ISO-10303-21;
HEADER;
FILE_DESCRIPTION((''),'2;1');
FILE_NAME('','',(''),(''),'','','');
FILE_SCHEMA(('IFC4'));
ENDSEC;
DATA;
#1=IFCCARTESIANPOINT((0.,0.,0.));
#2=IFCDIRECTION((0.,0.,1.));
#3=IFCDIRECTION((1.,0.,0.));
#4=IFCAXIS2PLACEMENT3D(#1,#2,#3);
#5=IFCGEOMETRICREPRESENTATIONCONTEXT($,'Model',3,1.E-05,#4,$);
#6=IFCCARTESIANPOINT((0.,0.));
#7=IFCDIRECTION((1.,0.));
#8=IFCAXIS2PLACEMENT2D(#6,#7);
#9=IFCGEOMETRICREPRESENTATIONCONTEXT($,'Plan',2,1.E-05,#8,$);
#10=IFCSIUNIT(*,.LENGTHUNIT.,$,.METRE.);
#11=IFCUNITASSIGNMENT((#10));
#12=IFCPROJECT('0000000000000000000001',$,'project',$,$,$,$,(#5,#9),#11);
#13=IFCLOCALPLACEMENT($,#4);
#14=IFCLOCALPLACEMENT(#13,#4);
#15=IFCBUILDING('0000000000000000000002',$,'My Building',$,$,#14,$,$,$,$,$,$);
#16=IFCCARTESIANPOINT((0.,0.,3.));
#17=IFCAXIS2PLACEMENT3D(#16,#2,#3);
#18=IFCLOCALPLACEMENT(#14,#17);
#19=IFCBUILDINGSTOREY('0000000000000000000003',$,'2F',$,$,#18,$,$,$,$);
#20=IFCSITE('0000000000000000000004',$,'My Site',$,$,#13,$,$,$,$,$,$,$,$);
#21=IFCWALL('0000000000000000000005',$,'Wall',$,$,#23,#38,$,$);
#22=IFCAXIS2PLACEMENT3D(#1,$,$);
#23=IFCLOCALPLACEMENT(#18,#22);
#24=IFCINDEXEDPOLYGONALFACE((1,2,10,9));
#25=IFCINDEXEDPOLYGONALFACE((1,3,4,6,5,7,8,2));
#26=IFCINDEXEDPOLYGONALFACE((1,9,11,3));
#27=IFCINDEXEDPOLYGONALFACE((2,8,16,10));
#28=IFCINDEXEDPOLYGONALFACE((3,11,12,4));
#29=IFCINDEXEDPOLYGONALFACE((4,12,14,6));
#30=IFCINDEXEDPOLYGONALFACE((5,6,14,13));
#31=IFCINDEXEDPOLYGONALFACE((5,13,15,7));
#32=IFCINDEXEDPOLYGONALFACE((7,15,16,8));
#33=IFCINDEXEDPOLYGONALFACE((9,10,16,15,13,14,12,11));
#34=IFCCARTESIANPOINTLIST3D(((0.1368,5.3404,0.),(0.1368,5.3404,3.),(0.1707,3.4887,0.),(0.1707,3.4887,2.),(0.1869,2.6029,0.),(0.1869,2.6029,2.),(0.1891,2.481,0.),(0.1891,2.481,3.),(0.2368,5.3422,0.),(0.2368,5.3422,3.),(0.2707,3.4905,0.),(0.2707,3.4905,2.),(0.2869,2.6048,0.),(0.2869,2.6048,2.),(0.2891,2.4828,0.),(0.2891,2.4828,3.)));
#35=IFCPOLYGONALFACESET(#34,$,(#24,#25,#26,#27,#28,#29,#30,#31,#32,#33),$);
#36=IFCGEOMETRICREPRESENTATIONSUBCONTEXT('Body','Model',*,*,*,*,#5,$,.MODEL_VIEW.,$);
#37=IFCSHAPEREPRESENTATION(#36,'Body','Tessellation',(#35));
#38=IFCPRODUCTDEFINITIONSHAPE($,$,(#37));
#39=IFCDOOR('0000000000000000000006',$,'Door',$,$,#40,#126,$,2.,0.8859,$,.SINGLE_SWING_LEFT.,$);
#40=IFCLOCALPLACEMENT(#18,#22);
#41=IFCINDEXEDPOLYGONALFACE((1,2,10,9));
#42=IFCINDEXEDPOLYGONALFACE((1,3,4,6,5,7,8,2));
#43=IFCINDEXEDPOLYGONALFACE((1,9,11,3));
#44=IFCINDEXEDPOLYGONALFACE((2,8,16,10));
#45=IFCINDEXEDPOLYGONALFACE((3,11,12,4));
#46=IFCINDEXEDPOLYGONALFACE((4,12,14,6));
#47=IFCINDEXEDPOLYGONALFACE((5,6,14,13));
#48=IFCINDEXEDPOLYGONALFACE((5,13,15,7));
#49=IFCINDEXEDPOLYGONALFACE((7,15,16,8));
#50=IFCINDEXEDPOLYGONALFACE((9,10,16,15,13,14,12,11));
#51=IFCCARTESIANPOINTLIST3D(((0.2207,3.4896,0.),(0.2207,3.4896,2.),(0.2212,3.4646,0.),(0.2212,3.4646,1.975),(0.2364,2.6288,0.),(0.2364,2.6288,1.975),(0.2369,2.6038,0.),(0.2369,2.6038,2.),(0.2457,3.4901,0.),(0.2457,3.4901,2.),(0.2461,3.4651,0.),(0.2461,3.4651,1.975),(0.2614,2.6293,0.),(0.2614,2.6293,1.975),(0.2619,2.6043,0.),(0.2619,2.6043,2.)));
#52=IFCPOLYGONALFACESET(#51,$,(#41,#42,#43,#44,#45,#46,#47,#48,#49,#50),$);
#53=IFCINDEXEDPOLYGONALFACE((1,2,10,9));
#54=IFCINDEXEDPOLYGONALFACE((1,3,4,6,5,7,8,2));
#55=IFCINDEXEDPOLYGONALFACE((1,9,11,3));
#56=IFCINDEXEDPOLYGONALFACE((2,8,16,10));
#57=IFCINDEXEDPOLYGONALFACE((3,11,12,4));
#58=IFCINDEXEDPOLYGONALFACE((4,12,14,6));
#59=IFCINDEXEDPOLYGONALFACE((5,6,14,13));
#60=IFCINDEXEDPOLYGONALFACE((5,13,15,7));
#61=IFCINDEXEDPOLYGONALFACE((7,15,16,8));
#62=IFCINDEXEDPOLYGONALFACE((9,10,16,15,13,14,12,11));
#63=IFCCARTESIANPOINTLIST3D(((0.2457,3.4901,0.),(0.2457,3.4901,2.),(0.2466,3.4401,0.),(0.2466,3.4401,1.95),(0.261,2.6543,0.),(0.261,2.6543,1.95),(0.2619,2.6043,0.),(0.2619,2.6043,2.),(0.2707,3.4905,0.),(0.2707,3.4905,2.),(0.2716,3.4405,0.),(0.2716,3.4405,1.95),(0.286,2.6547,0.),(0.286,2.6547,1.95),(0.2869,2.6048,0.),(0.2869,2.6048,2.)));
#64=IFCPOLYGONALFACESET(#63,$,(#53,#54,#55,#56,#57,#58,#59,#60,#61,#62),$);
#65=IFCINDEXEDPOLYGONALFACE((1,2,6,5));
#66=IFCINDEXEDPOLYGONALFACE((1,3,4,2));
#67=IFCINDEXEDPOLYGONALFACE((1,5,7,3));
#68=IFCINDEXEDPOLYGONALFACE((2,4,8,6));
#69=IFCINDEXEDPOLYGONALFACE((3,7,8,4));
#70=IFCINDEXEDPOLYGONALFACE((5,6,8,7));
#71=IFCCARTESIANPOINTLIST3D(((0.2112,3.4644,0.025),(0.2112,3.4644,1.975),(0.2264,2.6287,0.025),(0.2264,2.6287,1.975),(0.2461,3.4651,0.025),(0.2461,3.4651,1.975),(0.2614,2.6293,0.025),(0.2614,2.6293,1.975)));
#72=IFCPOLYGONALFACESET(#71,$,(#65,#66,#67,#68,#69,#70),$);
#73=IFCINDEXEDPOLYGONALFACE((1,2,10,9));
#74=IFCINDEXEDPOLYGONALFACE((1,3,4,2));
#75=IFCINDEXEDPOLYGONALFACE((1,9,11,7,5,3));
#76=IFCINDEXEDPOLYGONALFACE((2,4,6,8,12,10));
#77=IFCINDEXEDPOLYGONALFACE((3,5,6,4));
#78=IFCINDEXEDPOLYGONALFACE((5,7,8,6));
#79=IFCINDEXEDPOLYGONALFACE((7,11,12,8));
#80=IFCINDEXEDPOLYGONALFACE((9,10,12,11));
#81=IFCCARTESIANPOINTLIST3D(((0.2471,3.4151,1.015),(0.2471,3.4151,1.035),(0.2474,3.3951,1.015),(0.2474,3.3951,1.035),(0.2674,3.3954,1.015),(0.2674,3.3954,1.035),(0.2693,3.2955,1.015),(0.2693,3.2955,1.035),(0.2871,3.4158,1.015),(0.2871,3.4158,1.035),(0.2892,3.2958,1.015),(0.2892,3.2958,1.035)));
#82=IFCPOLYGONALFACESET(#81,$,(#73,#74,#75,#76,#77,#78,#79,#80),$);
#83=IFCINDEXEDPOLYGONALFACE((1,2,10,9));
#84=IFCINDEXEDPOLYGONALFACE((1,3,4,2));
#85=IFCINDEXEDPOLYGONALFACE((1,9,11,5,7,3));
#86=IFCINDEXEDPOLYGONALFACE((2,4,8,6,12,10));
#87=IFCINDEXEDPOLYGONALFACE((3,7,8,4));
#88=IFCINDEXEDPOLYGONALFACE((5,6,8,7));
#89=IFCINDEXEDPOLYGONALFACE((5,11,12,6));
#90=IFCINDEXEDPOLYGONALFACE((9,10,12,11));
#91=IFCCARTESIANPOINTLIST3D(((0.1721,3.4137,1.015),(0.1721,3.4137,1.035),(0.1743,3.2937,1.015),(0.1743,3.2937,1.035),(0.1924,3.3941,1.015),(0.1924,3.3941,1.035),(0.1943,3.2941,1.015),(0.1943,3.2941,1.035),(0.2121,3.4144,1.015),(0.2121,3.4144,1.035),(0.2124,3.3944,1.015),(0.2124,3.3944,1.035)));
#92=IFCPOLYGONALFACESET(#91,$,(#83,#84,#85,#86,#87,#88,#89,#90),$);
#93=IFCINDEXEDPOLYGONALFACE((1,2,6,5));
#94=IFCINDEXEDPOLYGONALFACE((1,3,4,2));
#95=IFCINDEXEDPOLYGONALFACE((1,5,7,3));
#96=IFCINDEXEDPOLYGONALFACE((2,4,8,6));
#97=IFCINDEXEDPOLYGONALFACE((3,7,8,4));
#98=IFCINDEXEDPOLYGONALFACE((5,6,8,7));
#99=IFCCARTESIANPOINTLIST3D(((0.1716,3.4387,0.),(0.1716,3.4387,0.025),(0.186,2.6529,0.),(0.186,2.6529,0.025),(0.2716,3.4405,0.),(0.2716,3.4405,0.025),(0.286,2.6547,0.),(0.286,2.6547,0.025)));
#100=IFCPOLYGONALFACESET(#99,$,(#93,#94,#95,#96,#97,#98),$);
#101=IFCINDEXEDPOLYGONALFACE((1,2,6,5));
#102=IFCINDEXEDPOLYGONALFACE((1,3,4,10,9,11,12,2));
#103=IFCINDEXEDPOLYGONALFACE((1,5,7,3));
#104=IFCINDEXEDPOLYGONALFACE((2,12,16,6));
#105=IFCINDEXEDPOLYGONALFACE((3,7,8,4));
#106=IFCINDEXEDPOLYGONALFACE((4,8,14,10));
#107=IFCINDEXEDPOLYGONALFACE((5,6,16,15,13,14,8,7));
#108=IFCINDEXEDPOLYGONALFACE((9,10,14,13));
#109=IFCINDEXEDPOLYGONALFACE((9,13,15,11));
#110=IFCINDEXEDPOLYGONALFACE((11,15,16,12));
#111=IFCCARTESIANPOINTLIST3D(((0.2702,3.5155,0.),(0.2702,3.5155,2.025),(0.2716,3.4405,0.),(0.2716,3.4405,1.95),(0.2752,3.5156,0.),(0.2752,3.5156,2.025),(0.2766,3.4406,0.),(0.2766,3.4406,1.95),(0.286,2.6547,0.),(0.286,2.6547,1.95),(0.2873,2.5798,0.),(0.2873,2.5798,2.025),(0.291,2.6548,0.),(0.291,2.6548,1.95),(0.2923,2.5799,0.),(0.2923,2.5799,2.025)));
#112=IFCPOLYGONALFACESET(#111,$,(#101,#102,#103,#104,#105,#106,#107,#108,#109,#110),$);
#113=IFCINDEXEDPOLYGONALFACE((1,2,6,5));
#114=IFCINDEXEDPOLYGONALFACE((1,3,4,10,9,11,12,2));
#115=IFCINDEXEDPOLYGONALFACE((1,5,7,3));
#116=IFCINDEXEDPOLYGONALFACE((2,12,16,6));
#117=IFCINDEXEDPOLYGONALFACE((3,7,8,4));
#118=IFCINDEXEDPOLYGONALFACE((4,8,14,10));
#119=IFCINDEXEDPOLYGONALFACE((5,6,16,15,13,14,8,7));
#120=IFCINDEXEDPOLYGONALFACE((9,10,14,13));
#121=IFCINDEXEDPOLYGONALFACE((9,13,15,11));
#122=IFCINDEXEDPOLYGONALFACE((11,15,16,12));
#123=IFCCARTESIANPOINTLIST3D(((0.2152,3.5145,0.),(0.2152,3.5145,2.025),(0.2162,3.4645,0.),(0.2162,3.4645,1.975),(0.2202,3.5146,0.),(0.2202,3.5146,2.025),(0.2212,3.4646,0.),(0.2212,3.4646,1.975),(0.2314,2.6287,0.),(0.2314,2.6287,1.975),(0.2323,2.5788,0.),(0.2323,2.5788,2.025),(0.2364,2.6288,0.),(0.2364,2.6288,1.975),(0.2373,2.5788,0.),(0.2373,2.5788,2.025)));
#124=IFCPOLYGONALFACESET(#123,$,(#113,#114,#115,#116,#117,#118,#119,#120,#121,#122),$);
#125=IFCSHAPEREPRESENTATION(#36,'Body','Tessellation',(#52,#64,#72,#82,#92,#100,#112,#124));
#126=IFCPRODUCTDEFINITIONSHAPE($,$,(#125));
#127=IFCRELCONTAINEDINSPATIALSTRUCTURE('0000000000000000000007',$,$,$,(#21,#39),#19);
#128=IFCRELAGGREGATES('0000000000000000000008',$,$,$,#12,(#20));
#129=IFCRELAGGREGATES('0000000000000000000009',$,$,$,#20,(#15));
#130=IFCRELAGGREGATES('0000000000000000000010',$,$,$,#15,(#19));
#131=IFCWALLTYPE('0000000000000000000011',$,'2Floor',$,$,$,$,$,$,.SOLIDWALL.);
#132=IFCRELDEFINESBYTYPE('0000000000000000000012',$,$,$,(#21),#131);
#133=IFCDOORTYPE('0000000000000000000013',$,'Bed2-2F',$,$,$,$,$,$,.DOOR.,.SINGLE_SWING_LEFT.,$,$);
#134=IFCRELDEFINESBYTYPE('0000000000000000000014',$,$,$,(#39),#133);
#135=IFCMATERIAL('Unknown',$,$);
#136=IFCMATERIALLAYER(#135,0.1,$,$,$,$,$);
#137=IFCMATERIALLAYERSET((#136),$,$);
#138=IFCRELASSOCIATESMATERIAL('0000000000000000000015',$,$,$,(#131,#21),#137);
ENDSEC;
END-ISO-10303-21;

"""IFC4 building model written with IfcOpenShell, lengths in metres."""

from ifc_helpers import new_model, entity, si_unit, frame, origin_with_axes, origin_2d_with_axis, place, context, subcontext, project, spatial, line, indexed_curve, outline, extrude, shape, source, transform, mapped, material, layer, layer_set, layer_usage, type_object, type_shapes, element, fill, save


model = new_model("IFC4")

# Units and contexts
model_context = context("Model", 3, precision=1e-05, world=origin_with_axes())
plan_context = context("Plan", 2, precision=1e-05, world=origin_2d_with_axis())
body_context_1 = subcontext(model_context, "Body", "Model", "MODEL_VIEW")
body_context_2 = subcontext(plan_context, "Body", "Plan", "PLAN_VIEW")
ifc_project = project(units=[si_unit("LENGTHUNIT", "METRE")], contexts=[model_context, plan_context])

# Site, building, storey
site_placement = place(None, origin_with_axes())
site = spatial("IfcSite", under=ifc_project, at=site_placement, Name="My Site")
building_placement = place(site_placement, origin_with_axes())
building = spatial("IfcBuilding", under=site, at=building_placement, Name="My Building")
storey_placement = place(building_placement, frame((0.0, 0.0, 3.0), z_axis=(0.0, 0.0, 1.0), x_axis=(1.0, 0.0, 0.0)))
storey = spatial("IfcBuildingStorey", under=building, at=storey_placement, Name="2F")

# Shared definitions
ifc_material = material(Name="Unknown")

# Shared definitions
ifc_layer_1 = layer(ifc_material, 0.1)
ifc_layer_set_1 = layer_set([ifc_layer_1])
wall_type = type_object("IfcWallType", Name="2Floor", PredefinedType="SOLIDWALL", material=ifc_layer_set_1)

# Shared definitions
shared_shape_1 = source(origin_with_axes(), body_context_1, "Body", "SweptSolid", [
    extrude(outline(indexed_curve([(0.0, 0.0), (0.8859, 0.0), (0.8859, 2.0), (0.0, 2.0)], segments=[line(1, 2, 3, 4, 1)])), frame((0.0, -0.6, 0.0), z_axis=(0.0, -1.0, 0.0), x_axis=(1.0, 0.0, 0.0)), (0.0, 0.0, -1.0), 1.2),
])
door_type_1 = type_object("IfcDoorType", Name="Bed2-2F", OperationType="SINGLE_SWING_LEFT", PredefinedType="DOOR")
shared_shape_2 = source(origin_with_axes(), body_context_1, "Body", "SweptSolid", [
    extrude(outline(indexed_curve([(0.0, 0.0), (0.0, 2.0), (0.8859, 2.0), (0.8859, 0.0), (0.8609, 0.0), (0.8609, 1.975), (0.025, 1.975), (0.025, 0.0)], segments=[line(1, 2, 3, 4, 5, 6, 7, 8, 1)])), frame((0.0, 0.025, 0.0), z_axis=(0.0, -1.0, 0.0), x_axis=(1.0, 0.0, 0.0)), (0.0, 0.0, -1.0), 0.025),
    extrude(outline(indexed_curve([(0.0, 0.0), (0.0, 2.0), (0.8859, 2.0), (0.8859, 0.0), (0.8359, 0.0), (0.8359, 1.95), (0.05, 1.95), (0.05, 0.0)], segments=[line(1, 2, 3, 4, 5, 6, 7, 8, 1)])), frame((0.0, 0.0, 0.0), z_axis=(0.0, -1.0, 0.0), x_axis=(1.0, 0.0, 0.0)), (0.0, 0.0, -1.0), 0.025),
    extrude(outline(indexed_curve([(0.0, 0.0), (0.8359, 0.0), (0.8359, 0.035), (0.0, 0.035)], segments=[line(1, 2, 3, 4, 1)])), frame((0.025, 0.025, 0.025), z_axis=(0.0, 0.0, 1.0), x_axis=(1.0, 0.0, 0.0)), (0.0, 0.0, 1.0), 1.95),
    extrude(outline(indexed_curve([(0.0, 0.0), (0.0, -0.04), (-0.12, -0.04), (-0.12, -0.02), (-0.02, -0.02), (-0.02, 0.0)], segments=[line(1, 2, 3, 4, 5, 6, 1)])), frame((0.8109, 0.025, 1.015), z_axis=(0.0, 0.0, 1.0), x_axis=(1.0, 0.0, 0.0)), (0.0, 0.0, 1.0), 0.02),
    extrude(outline(indexed_curve([(0.0, 0.0), (0.0, 0.04), (-0.12, 0.04), (-0.12, 0.02), (-0.02, 0.02), (-0.02, 0.0)], segments=[line(1, 2, 3, 4, 5, 6, 1)])), frame((0.8109, 0.06, 1.015), z_axis=(0.0, 0.0, 1.0), x_axis=(1.0, 0.0, 0.0)), (0.0, 0.0, 1.0), 0.02),
    extrude(outline(indexed_curve([(0.0, 0.0), (0.7859, 0.0), (0.7859, 0.1), (0.0, 0.1)], segments=[line(1, 2, 3, 4, 1)])), frame((0.05, 0.0, 0.0), z_axis=(0.0, 0.0, 1.0), x_axis=(1.0, 0.0, 0.0)), (0.0, 0.0, 1.0), 0.025),
    extrude(outline(indexed_curve([(0.0, 0.0), (0.0, 2.025), (0.9359, 2.025), (0.9359, 0.0), (0.8609, 0.0), (0.8609, 1.95), (0.075, 1.95), (0.075, 0.0)], segments=[line(1, 2, 3, 4, 5, 6, 7, 8, 1)])), frame((-0.025, -0.005, 0.0), z_axis=(0.0, -1.0, 0.0), x_axis=(1.0, 0.0, 0.0)), (0.0, 0.0, -1.0), 0.005),
    extrude(outline(indexed_curve([(0.0, 0.0), (0.0, 2.025), (0.9359, 2.025), (0.9359, 0.0), (0.8859, 0.0), (0.8859, 1.975), (0.05, 1.975), (0.05, 0.0)], segments=[line(1, 2, 3, 4, 5, 6, 7, 8, 1)])), frame((-0.025, 0.05, 0.0), z_axis=(0.0, -1.0, 0.0), x_axis=(1.0, 0.0, 0.0)), (0.0, 0.0, -1.0), 0.005),
])
shared_shape_3 = source(origin_with_axes(), body_context_2, "Body", "Curve2D", [
    entity("IfcIndexedPolyCurve", entity("IfcCartesianPointList2D", [[0.0, 0.0], [0.0, 0.05], [0.025, 0.05], [0.025, 0.025], [0.05, 0.025], [0.05, 0.0]]), [entity("IfcLineIndex", [1, 2, 3, 4, 5, 6, 1])]),
    entity("IfcIndexedPolyCurve", entity("IfcCartesianPointList2D", [[0.8859, 0.0], [0.8859, 0.05], [0.8609, 0.05], [0.8609, 0.025], [0.8359, 0.025], [0.8359, 0.0]]), [entity("IfcLineIndex", [1, 2, 3, 4, 5, 6, 1])]),
    entity("IfcTrimmedCurve", entity("IfcEllipse", entity("IfcAxis2Placement2D", entity("IfcCartesianPoint", [0.06, 0.05]), entity("IfcDirection", [1.0, 0.0])), 0.8009, 0.8359), [entity("IfcCartesianPoint", [0.8609, 0.05])], [entity("IfcCartesianPoint", [0.06, 0.8859])], True, "CARTESIAN"),
    entity("IfcIndexedPolyCurve", entity("IfcCartesianPointList2D", [[0.025, 0.05], [0.06, 0.05], [0.06, 0.8859], [0.025, 0.8859]]), [entity("IfcLineIndex", [1, 2, 3, 4, 1])]),
])
type_shapes(door_type_1, [shared_shape_2, shared_shape_3])

# Wall, opening, door
ifc_layer_usage_1 = layer_usage(ifc_layer_set_1, "AXIS2", "POSITIVE", 0.0)
wall_1_placement = place(storey_placement, frame((0.2891, 2.4828, 0.0), z_axis=(0.0, 0.0, 1.0), x_axis=(-0.018281, 0.999833, 0.0)))
wall_1 = element("IfcWall", 1, at=wall_1_placement, inside=storey, type_object=wall_type, material=ifc_layer_usage_1, Name="Wall", context=body_context_1, shape_type="SweptSolid", body=[
    extrude(outline(indexed_curve([(0.0, 0.0), (0.0, 0.1), (2.8598, 0.1), (2.8598, 0.0)], segments=[line(1, 2, 3, 4, 1)])), origin_with_axes(), (0.0, 0.0, 1.0), 3.0),
])
opening_1_placement = place(wall_1_placement, frame((0.1219, 0.0, 0.0), z_axis=(0.0, 0.0, 1.0), x_axis=(1.0, 0.0, 0.0)))
opening_1 = element("IfcOpeningElement", 2, at=opening_1_placement, cuts=wall_1, PredefinedType="OPENING", context=body_context_1, shape_type="MappedRepresentation", body=[
    mapped(shared_shape_1, transform((0.0, 0.0, 0.0), x_axis=(1.0, 0.0, 0.0), y_axis=(0.0, 1.0, 0.0), z_axis=(0.0, 0.0, 1.0), scale=1.0)),
])
door_1_placement = place(opening_1_placement, frame((0.0, 0.0, 0.0), z_axis=(0.0, 0.0, 1.0), x_axis=(1.0, 0.0, 0.0)))
door_1 = element("IfcDoor", 3, at=door_1_placement, inside=storey, type_object=door_type_1, Name="Door", OperationType="SINGLE_SWING_LEFT", OverallHeight=2.0, OverallWidth=0.8859, shapes=[
    shape(body_context_1, "Body", "MappedRepresentation", [mapped(shared_shape_2, transform((0.0, 0.0, 0.0), x_axis=(1.0, 0.0, 0.0), y_axis=(0.0, 1.0, 0.0), z_axis=(0.0, 0.0, 1.0), scale=1.0))]),
    shape(body_context_2, "Body", "MappedRepresentation", [mapped(shared_shape_3, transform((0.0, 0.0, 0.0), x_axis=(1.0, 0.0, 0.0), y_axis=(0.0, 1.0, 0.0), z_axis=(0.0, 0.0, 1.0), scale=1.0))]),
])
fill(opening_1, door_1)

save(model, "model.ifc")
